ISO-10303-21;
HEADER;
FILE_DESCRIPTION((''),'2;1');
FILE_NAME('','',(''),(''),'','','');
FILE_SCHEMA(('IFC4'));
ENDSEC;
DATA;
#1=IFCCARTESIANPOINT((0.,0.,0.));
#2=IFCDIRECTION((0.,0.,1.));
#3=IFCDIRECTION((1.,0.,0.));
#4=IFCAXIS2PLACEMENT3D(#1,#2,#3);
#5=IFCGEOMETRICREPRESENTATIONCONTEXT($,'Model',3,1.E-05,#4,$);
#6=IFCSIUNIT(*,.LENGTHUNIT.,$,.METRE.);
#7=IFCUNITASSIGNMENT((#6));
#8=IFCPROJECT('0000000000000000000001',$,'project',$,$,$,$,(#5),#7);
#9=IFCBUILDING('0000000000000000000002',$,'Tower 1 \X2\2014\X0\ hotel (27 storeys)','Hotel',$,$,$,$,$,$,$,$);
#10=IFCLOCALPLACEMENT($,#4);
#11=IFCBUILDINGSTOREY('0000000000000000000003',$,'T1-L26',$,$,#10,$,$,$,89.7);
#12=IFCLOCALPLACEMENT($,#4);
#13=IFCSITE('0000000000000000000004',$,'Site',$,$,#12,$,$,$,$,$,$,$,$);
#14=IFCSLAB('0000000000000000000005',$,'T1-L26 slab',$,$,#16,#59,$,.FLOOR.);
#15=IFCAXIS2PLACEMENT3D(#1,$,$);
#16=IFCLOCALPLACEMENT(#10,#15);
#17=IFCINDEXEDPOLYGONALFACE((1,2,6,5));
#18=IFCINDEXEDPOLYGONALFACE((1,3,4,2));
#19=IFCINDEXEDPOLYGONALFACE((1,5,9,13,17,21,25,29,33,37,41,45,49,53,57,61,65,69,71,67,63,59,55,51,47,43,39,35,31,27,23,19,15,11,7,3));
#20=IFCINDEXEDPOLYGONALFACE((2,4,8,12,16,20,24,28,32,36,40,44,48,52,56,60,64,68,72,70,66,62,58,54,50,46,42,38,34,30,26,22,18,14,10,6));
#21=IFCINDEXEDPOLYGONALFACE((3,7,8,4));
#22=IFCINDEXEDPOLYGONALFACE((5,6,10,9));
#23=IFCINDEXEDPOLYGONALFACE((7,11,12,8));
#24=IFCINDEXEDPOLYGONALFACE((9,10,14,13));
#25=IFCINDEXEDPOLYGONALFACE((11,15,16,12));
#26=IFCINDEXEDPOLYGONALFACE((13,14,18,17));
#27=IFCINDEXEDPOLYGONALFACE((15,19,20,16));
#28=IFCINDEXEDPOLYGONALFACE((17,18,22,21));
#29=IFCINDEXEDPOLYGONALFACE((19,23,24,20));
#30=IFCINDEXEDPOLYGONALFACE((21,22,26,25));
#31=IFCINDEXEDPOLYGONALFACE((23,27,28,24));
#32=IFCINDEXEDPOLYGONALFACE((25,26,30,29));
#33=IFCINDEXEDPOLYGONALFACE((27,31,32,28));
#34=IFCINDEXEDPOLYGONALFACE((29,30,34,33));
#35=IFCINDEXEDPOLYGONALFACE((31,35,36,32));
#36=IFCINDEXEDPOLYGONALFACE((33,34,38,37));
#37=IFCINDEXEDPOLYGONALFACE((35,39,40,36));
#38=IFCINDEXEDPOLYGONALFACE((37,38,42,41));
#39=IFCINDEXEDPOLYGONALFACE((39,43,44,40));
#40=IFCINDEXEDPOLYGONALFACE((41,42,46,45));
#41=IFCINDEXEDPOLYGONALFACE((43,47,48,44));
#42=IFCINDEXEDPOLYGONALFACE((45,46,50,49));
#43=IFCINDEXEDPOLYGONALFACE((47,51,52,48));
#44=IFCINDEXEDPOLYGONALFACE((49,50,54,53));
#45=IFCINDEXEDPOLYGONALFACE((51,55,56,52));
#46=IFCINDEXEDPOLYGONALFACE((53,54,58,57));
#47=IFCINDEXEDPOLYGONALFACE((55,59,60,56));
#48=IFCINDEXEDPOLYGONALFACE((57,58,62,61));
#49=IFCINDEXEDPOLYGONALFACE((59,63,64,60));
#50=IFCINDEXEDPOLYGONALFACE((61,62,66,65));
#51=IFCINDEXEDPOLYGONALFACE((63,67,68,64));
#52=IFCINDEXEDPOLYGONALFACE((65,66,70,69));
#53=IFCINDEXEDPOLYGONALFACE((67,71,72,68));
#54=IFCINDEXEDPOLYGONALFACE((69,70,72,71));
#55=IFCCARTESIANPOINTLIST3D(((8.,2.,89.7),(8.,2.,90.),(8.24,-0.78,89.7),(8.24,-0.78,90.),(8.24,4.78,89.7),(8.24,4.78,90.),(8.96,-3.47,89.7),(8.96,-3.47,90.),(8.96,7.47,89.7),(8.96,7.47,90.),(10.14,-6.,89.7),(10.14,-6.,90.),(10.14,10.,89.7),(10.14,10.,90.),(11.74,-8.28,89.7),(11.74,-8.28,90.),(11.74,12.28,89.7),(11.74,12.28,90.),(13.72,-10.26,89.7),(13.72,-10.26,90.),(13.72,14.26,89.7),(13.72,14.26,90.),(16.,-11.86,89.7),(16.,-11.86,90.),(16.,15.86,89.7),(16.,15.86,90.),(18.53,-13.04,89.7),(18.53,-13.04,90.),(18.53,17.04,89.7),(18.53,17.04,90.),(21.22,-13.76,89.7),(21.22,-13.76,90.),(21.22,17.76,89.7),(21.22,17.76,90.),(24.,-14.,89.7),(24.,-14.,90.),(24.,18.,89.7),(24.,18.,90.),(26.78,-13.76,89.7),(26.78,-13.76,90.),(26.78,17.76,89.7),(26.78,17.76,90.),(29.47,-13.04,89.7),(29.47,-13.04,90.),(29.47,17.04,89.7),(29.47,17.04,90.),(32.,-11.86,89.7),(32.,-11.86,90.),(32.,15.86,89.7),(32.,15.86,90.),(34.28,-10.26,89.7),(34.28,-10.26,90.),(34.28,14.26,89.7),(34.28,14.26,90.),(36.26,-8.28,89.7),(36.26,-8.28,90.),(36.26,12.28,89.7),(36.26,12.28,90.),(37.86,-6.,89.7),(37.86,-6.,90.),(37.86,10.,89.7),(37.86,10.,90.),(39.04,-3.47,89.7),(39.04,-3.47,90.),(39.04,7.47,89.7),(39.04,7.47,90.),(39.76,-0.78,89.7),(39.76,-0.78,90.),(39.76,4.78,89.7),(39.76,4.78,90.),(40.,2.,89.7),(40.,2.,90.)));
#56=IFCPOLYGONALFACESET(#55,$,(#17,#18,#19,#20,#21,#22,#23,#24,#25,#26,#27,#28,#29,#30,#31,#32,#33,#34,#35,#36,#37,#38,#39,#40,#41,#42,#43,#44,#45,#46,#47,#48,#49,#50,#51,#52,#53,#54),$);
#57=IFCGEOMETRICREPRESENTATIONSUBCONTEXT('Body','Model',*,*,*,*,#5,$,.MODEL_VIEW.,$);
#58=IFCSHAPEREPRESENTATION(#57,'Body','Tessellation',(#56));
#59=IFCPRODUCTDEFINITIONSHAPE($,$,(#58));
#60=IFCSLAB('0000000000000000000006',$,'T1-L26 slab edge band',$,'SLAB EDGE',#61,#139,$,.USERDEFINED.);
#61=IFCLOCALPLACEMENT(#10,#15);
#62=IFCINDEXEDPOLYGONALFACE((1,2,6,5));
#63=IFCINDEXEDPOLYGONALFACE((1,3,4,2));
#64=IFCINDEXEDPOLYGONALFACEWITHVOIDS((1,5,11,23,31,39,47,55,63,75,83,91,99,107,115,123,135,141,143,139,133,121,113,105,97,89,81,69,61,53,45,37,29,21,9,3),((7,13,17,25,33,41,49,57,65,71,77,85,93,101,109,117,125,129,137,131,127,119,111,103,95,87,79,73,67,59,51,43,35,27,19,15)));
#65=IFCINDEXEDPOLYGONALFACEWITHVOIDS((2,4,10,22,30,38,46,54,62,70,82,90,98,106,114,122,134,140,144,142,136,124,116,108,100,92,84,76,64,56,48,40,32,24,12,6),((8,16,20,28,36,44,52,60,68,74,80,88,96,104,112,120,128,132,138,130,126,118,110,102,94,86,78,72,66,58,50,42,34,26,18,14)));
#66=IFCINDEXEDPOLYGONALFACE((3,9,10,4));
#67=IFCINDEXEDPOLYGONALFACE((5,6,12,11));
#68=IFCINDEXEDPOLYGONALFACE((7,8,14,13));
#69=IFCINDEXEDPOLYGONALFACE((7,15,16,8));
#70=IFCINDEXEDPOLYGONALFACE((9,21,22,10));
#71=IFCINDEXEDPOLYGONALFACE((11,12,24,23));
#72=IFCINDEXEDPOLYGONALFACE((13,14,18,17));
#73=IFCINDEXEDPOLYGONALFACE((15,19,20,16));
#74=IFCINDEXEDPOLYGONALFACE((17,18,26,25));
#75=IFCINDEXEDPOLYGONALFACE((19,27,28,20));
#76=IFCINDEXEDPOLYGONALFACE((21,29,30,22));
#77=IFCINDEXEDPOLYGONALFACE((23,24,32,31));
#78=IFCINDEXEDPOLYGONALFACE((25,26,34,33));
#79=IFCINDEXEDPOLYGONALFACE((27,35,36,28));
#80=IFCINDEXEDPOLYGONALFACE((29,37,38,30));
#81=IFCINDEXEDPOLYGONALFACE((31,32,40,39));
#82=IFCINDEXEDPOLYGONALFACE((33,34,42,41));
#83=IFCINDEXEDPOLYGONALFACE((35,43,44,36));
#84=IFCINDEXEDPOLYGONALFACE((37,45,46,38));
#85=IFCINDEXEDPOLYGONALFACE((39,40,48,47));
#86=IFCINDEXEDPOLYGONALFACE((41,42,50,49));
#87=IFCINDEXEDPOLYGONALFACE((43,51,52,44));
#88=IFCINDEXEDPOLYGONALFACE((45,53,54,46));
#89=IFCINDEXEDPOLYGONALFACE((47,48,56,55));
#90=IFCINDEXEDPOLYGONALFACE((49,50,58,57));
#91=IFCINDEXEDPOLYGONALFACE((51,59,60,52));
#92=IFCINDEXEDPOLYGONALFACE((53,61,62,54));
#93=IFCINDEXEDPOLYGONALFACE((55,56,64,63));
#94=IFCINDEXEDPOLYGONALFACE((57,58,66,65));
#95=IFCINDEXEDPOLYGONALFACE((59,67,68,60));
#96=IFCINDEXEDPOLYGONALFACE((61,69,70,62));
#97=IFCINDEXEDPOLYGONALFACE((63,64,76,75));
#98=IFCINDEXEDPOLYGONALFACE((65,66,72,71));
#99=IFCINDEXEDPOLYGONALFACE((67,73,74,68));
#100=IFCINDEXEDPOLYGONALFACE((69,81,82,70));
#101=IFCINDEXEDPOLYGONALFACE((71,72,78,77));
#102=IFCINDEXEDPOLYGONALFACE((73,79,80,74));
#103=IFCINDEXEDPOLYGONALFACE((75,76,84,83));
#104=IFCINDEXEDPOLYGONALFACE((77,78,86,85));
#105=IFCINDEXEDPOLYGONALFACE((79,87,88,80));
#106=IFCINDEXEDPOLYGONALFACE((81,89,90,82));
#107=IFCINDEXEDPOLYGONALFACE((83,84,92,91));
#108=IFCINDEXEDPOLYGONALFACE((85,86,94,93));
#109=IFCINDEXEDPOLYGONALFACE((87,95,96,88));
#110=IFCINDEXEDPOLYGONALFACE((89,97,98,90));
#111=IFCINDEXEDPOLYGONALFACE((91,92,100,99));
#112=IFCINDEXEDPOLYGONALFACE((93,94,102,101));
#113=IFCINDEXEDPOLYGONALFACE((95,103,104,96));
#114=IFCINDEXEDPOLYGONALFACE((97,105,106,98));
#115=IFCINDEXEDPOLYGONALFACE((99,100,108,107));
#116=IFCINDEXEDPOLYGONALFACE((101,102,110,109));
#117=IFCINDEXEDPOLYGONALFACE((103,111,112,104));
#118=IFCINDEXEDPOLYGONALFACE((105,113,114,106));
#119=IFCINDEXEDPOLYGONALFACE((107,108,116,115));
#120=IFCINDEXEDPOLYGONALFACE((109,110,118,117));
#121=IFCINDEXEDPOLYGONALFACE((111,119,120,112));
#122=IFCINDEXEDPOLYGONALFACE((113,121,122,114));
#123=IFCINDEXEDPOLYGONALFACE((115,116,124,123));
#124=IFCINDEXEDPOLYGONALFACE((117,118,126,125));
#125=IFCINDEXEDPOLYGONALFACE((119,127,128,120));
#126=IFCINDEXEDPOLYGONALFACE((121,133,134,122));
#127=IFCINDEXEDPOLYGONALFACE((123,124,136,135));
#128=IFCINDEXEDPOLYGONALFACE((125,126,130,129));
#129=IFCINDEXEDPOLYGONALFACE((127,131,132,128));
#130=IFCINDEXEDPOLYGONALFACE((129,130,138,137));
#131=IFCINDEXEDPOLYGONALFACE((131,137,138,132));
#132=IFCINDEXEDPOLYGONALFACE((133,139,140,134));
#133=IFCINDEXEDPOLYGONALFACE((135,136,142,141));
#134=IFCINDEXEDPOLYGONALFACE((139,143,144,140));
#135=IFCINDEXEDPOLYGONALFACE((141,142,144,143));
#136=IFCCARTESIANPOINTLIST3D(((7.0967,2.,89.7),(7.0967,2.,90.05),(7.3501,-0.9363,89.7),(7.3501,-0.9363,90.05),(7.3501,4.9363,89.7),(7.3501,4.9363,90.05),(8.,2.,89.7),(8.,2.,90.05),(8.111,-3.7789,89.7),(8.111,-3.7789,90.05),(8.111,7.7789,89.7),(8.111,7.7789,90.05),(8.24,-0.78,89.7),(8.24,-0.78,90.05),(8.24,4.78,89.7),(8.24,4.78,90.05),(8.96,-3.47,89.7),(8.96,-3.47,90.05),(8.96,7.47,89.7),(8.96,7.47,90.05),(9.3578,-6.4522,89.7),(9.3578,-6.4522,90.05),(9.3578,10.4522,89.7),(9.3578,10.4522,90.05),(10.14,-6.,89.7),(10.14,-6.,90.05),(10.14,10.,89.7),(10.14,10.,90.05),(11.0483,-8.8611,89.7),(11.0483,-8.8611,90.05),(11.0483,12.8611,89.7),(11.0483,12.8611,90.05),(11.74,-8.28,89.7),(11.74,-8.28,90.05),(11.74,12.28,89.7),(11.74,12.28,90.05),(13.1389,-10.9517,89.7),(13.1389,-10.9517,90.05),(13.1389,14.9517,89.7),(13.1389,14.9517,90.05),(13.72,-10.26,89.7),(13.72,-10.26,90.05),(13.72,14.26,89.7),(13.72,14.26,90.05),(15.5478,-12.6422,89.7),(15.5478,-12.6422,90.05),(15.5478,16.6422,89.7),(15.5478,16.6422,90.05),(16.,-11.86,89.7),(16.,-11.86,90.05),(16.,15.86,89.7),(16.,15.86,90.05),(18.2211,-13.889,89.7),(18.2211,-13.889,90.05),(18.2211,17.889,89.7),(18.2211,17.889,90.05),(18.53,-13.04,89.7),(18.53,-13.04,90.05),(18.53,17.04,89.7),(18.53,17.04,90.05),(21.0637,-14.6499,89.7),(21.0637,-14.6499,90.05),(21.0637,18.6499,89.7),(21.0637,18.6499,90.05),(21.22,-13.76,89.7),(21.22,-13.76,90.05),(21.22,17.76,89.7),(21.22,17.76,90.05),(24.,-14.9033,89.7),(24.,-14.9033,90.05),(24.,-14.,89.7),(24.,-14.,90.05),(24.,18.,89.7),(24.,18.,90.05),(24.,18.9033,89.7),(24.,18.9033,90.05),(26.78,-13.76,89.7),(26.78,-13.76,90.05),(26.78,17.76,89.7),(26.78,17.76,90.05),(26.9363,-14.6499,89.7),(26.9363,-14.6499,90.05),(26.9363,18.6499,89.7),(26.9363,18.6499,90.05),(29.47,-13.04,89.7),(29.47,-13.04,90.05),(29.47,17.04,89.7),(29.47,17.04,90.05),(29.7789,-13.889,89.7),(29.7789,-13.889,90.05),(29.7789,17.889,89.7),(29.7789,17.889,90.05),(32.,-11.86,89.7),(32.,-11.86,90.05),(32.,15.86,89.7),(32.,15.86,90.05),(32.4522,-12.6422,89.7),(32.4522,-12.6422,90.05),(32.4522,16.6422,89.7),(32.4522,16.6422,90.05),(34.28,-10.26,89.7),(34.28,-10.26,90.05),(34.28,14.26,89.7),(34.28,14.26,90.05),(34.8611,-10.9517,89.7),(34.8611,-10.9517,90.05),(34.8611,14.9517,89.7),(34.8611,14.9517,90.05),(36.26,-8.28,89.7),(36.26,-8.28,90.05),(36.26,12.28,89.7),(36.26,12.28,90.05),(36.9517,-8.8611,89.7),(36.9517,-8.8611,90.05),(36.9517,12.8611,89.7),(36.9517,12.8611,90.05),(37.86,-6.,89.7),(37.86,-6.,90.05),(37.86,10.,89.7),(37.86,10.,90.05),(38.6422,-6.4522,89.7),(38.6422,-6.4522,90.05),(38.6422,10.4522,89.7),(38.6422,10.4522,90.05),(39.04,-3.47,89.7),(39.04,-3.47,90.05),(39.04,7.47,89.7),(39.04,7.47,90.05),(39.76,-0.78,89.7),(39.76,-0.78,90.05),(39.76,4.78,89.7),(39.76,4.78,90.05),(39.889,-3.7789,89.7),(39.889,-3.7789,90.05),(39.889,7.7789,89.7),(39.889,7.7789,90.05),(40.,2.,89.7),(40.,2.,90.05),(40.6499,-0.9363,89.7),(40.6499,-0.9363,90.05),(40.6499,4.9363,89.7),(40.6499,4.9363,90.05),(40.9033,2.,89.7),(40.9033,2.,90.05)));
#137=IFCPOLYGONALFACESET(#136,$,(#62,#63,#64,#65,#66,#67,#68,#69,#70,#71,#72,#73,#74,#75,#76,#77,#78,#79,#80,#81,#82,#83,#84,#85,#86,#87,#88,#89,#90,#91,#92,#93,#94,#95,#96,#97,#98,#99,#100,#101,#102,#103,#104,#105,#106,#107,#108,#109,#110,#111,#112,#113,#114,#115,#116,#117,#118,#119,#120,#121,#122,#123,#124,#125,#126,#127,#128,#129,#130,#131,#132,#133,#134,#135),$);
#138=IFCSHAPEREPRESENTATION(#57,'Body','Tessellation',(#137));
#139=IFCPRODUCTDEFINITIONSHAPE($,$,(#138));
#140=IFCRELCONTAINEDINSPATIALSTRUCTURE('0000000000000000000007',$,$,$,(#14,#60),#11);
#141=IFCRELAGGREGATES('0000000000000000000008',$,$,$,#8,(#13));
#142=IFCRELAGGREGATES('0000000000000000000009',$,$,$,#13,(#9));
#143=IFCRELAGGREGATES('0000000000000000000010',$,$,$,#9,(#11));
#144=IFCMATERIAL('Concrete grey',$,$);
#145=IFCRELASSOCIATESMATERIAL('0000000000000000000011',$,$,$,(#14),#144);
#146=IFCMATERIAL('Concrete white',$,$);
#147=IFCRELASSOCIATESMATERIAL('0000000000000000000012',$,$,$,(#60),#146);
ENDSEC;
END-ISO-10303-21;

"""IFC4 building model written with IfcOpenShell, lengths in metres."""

from ifc_helpers import new_model, si_unit, frame, origin_with_axes, place, context, subcontext, project, spatial, polyline, outline, extrude, material, element, save


model = new_model("IFC4")

# Units and contexts
model_context = context("Model", 3, precision=1e-05, world=origin_with_axes())
body_context = subcontext(model_context, "Body", "Model", "MODEL_VIEW")
ifc_project = project(units=[si_unit("LENGTHUNIT", "METRE")], contexts=[model_context])

# Site, building, storey
site_placement = place(None, origin_with_axes())
site = spatial("IfcSite", under=ifc_project, at=site_placement, Name="Site")
building = spatial("IfcBuilding", under=site, Name="Tower 1 — hotel (27 storeys)", Description="Hotel")
storey_placement = place(None, origin_with_axes())
storey = spatial("IfcBuildingStorey", under=building, at=storey_placement, Name="T1-L26", Elevation=89.7)

# Slab
ifc_material_1 = material(Name="Concrete grey")
slab_1_placement = place(storey_placement, origin_with_axes())
element("IfcSlab", 1, at=slab_1_placement, inside=storey, material=ifc_material_1, Name="T1-L26 slab", PredefinedType="FLOOR", context=body_context, shape_type="SweptSolid", body=[
    extrude(outline(polyline([(40.0, 2.0), (39.76, 4.78), (39.04, 7.47), (37.86, 10.0), (36.26, 12.28), (34.28, 14.26), (32.0, 15.86), (29.47, 17.04), (26.78, 17.76), (24.0, 18.0), (21.22, 17.76), (18.53, 17.04), (16.0, 15.86), (13.72, 14.26), (11.74, 12.28), (10.14, 10.0), (8.96, 7.47), (8.24, 4.78), (8.0, 2.0), (8.24, -0.78), (8.96, -3.47), (10.14, -6.0), (11.74, -8.28), (13.72, -10.26), (16.0, -11.86), (18.53, -13.04), (21.22, -13.76), (24.0, -14.0), (26.78, -13.76), (29.47, -13.04), (32.0, -11.86), (34.28, -10.26), (36.26, -8.28), (37.86, -6.0), (39.04, -3.47), (39.76, -0.78), (40.0, 2.0)])), frame((0.0, 0.0, 89.7), z_axis=(0.0, 0.0, 1.0), x_axis=(1.0, 0.0, 0.0)), (0.0, 0.0, 1.0), 0.3),
])

# Slab
ifc_material_2 = material(Name="Concrete white")
slab_2_placement = place(storey_placement, origin_with_axes())
element("IfcSlab", 2, at=slab_2_placement, inside=storey, material=ifc_material_2, Name="T1-L26 slab edge band", ObjectType="SLAB EDGE", PredefinedType="USERDEFINED", context=body_context, shape_type="SweptSolid", body=[
    extrude(outline(polyline([(40.9033, 2.0), (40.6499, 4.9363), (39.889, 7.7789), (38.6422, 10.4522), (36.9517, 12.8611), (34.8611, 14.9517), (32.4522, 16.6422), (29.7789, 17.889), (26.9363, 18.6499), (24.0, 18.9033), (21.0637, 18.6499), (18.2211, 17.889), (15.5478, 16.6422), (13.1389, 14.9517), (11.0483, 12.8611), (9.3578, 10.4522), (8.111, 7.7789), (7.3501, 4.9363), (7.0967, 2.0), (7.3501, -0.9363), (8.111, -3.7789), (9.3578, -6.4522), (11.0483, -8.8611), (13.1389, -10.9517), (15.5478, -12.6422), (18.2211, -13.889), (21.0637, -14.6499), (24.0, -14.9033), (26.9363, -14.6499), (29.7789, -13.889), (32.4522, -12.6422), (34.8611, -10.9517), (36.9517, -8.8611), (38.6422, -6.4522), (39.889, -3.7789), (40.6499, -0.9363), (40.9033, 2.0)]), holes=[polyline([(40.0, 2.0), (39.76, 4.78), (39.04, 7.47), (37.86, 10.0), (36.26, 12.28), (34.28, 14.26), (32.0, 15.86), (29.47, 17.04), (26.78, 17.76), (24.0, 18.0), (21.22, 17.76), (18.53, 17.04), (16.0, 15.86), (13.72, 14.26), (11.74, 12.28), (10.14, 10.0), (8.96, 7.47), (8.24, 4.78), (8.0, 2.0), (8.24, -0.78), (8.96, -3.47), (10.14, -6.0), (11.74, -8.28), (13.72, -10.26), (16.0, -11.86), (18.53, -13.04), (21.22, -13.76), (24.0, -14.0), (26.78, -13.76), (29.47, -13.04), (32.0, -11.86), (34.28, -10.26), (36.26, -8.28), (37.86, -6.0), (39.04, -3.47), (39.76, -0.78), (40.0, 2.0)])]), frame((0.0, 0.0, 89.7), z_axis=(0.0, 0.0, 1.0), x_axis=(1.0, 0.0, 0.0)), (0.0, 0.0, 1.0), 0.35),
])

save(model, "model.ifc")
